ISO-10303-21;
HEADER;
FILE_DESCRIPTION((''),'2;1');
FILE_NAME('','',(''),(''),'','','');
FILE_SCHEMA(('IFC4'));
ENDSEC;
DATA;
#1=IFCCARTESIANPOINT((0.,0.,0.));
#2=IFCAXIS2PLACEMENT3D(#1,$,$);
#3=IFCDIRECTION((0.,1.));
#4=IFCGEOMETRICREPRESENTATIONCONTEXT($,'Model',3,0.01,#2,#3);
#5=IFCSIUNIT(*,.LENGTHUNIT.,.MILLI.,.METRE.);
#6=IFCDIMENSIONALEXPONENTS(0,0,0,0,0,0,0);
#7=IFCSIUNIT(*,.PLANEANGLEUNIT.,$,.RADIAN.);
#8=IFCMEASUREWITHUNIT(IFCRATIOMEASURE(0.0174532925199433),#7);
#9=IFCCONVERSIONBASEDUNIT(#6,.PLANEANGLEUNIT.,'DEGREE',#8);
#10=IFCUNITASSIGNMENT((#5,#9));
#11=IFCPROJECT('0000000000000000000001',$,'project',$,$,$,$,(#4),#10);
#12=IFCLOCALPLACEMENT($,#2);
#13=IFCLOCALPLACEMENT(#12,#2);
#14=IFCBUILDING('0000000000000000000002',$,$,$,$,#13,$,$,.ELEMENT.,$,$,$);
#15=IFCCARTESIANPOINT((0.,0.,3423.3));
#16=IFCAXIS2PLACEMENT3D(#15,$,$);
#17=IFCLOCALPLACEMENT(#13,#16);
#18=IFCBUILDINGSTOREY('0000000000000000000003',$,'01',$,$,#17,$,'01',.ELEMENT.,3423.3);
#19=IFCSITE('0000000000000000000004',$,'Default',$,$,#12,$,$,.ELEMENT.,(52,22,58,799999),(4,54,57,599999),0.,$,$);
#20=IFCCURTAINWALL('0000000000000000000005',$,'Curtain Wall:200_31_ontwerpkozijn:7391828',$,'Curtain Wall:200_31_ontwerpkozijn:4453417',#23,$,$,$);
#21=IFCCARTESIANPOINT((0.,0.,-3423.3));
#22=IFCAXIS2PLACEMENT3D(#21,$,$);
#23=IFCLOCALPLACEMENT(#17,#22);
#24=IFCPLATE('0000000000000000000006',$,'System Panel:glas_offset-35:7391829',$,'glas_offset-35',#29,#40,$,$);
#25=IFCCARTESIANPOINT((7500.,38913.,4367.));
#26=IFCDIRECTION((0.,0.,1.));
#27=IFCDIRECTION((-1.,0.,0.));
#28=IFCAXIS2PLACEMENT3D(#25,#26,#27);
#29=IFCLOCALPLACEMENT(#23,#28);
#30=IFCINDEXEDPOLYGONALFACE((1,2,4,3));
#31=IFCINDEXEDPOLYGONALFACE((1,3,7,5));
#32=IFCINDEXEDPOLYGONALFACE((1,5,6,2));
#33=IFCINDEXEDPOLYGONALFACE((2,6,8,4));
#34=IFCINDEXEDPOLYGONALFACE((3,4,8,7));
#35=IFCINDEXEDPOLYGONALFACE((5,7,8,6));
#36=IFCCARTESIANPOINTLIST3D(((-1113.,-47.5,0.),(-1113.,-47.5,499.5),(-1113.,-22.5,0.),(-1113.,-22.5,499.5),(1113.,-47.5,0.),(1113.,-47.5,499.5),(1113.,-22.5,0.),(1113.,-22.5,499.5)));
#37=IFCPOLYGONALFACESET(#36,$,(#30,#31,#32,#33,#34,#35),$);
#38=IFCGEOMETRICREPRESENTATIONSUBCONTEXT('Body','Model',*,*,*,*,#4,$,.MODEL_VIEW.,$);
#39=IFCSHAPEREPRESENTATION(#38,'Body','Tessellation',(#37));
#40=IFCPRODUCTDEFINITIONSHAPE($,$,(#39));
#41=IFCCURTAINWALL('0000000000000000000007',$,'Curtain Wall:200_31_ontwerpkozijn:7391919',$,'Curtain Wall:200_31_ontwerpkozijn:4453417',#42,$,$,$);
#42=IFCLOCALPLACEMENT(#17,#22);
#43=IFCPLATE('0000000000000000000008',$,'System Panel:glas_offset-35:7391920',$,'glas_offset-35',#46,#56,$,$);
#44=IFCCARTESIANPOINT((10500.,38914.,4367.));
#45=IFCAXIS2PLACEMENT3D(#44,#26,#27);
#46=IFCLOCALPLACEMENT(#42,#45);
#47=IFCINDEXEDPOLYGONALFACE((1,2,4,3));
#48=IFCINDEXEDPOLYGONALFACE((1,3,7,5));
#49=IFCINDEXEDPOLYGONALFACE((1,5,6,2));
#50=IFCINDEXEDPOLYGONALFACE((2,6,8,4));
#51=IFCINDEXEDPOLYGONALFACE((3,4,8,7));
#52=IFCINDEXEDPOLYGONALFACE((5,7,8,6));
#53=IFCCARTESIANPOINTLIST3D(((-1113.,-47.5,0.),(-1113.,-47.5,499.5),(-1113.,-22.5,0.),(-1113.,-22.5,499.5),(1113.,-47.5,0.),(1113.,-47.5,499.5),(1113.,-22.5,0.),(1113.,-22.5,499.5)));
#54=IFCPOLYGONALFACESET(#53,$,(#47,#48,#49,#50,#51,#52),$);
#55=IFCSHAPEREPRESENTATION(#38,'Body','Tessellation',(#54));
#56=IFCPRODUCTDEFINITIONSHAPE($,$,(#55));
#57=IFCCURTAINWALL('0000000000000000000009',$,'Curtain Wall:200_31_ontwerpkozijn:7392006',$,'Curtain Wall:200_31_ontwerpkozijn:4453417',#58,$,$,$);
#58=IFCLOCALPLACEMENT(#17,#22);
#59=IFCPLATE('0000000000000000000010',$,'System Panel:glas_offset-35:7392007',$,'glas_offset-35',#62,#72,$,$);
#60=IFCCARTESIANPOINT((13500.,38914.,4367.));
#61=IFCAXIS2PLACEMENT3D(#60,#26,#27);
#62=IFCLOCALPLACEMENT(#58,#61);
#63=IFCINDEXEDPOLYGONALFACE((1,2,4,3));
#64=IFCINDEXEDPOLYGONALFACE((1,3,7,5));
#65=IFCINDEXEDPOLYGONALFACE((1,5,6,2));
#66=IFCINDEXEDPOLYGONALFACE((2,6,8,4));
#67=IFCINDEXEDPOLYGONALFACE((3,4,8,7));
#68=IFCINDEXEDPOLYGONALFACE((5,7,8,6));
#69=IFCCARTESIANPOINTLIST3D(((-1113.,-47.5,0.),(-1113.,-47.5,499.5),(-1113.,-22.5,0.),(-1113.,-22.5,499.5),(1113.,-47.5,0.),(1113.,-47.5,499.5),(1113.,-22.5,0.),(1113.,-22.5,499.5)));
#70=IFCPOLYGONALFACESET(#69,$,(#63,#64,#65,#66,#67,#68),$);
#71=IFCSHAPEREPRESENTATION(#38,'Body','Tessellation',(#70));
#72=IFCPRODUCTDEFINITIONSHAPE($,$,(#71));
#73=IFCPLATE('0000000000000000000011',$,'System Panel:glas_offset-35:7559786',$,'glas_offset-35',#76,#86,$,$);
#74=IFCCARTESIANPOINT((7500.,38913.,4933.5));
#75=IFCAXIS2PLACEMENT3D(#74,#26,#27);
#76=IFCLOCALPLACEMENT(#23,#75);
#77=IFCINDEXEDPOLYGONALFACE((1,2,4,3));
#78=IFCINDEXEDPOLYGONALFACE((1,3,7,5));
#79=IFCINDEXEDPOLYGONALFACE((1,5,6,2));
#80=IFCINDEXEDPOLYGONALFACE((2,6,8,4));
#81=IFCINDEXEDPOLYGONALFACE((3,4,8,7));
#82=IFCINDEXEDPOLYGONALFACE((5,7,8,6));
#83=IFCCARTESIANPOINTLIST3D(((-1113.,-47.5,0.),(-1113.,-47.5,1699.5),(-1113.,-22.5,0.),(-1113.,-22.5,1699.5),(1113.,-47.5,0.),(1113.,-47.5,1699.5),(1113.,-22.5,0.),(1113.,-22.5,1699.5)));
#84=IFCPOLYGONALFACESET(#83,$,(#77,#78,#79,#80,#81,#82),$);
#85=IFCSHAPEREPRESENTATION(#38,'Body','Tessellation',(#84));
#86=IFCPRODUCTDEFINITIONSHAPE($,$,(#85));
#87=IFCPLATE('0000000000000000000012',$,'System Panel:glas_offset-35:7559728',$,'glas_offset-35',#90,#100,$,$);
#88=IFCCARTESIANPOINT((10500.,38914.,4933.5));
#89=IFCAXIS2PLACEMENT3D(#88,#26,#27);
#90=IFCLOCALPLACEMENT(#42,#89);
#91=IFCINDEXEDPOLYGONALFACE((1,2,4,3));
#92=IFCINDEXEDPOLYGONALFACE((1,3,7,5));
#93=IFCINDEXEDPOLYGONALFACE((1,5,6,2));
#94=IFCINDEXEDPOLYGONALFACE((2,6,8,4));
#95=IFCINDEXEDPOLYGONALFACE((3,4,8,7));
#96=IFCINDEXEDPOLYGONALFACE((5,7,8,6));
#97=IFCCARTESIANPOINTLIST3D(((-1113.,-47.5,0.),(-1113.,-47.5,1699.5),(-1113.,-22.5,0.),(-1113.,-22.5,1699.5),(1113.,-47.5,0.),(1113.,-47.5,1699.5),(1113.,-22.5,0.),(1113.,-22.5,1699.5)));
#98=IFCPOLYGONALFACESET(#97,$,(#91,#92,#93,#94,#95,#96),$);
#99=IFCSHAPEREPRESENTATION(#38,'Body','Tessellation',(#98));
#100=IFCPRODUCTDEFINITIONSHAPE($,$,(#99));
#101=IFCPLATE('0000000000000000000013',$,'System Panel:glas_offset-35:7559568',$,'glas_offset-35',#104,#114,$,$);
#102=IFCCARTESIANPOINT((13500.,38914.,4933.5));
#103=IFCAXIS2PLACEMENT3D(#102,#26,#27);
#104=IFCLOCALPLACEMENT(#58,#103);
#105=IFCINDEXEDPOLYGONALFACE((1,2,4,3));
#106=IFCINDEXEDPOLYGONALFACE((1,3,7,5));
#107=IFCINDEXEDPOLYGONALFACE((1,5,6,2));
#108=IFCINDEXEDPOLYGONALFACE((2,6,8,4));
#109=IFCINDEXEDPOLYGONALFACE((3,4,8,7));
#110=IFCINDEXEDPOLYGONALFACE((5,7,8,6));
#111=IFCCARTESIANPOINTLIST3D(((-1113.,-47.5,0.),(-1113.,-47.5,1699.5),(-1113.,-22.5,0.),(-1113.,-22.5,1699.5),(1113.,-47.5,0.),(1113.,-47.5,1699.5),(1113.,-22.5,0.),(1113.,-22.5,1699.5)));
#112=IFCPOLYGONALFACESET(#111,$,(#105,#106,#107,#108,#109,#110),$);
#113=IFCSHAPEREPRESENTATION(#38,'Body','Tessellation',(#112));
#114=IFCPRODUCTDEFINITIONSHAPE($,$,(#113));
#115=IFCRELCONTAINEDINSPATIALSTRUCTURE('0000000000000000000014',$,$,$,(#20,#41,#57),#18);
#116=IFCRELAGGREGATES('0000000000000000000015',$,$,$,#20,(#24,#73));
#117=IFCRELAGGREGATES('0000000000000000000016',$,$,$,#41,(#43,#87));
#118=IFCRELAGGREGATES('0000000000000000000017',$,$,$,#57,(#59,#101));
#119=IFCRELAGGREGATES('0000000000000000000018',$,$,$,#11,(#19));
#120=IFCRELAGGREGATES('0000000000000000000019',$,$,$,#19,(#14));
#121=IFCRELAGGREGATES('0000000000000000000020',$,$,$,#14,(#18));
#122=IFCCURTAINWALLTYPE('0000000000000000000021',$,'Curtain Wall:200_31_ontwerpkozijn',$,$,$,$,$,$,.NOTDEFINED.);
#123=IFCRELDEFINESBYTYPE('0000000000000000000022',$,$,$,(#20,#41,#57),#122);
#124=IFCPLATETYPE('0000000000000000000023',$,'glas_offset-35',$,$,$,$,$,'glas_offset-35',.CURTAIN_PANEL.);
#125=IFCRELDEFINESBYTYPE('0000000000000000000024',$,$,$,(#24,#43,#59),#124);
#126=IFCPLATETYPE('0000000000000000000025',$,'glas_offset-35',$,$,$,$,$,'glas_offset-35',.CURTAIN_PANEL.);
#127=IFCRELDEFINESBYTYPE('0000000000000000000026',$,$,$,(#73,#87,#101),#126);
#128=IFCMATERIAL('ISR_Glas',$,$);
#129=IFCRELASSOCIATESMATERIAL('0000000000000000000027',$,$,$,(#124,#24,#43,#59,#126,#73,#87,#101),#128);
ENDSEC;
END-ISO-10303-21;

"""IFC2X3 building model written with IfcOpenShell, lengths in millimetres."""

from ifc_helpers import new_model, entity, si_unit, converted_unit, direction, frame, frame_2d, origin, place, context, subcontext, project, spatial, rectangle, extrude, source, transform, mapped, material, type_object, type_shapes, element, aggregate, save


model = new_model("IFC2X3")

# Units and contexts
model_context = context("Model", 3, precision=0.01, world=origin(), true_north=direction((0.0, 1.0)))
body_context = subcontext(model_context, "Body", "Model", "MODEL_VIEW")
ifc_project = project(units=[si_unit("LENGTHUNIT", "METRE", prefix="MILLI"), converted_unit("PLANEANGLEUNIT", "DEGREE", entity("IfcRatioMeasure", 0.0174532925199433), si_unit("PLANEANGLEUNIT", "RADIAN"), dimensions=[0, 0, 0, 0, 0, 0, 0])], contexts=[model_context])

# Site, building, storey
site_placement = place(None, origin())
site = spatial("IfcSite", under=ifc_project, at=site_placement, Name="Default", CompositionType="ELEMENT", RefLatitude=(52, 22, 58, 799999), RefLongitude=(4, 54, 57, 599999), RefElevation=0.0)
building_placement = place(site_placement, origin())
building = spatial("IfcBuilding", under=site, at=building_placement, CompositionType="ELEMENT")
storey_placement = place(building_placement, frame((0.0, 0.0, 3423.3)))
storey = spatial("IfcBuildingStorey", under=building, at=storey_placement, Name="01", LongName="01", CompositionType="ELEMENT", Elevation=3423.3)

# Curtain walls, plates
curtain_wall_type = type_object("IfcCurtainWallType", Name="Curtain Wall:200_31_ontwerpkozijn", PredefinedType="NOTDEFINED")
curtain_wall_1_placement = place(storey_placement, frame((0.0, 0.0, -3423.3)))
curtain_wall_1 = element("IfcCurtainWall", 1, at=curtain_wall_1_placement, inside=storey, type_object=curtain_wall_type, Name="Curtain Wall:200_31_ontwerpkozijn:7391828", ObjectType="Curtain Wall:200_31_ontwerpkozijn:4453417")
ifc_material_1 = material(Name="ISR_Glas")
plate_type_1 = type_object("IfcPlateType", Name="glas_offset-35", ElementType="glas_offset-35", PredefinedType="CURTAIN_PANEL", material=ifc_material_1)
shared_shape_1 = source(origin(), body_context, "Body", "SweptSolid", [
    extrude(rectangle(XDim=25.0, YDim=2226.0, at=frame_2d((0.0, 0.0), x_axis=(1.0, 0.0))), frame((0.0, -35.0, 0.0), z_axis=(0.0, 0.0, 1.0), x_axis=(0.0, 1.0, 0.0)), (0.0, 0.0, 1.0), 499.5),
])
type_shapes(plate_type_1, [shared_shape_1])
plate_1_placement = place(curtain_wall_1_placement, frame((7500.0, 38913.0, 4367.0), z_axis=(0.0, 0.0, 1.0), x_axis=(-1.0, 0.0, 0.0)))
plate_1 = element("IfcPlate", 2, at=plate_1_placement, type_object=plate_type_1, material=ifc_material_1, Name="System Panel:glas_offset-35:7391829", ObjectType="glas_offset-35", context=body_context, shape_type="MappedRepresentation", body=[
    mapped(shared_shape_1, transform((0.0, 0.0, 0.0), scale=1.0)),
])
curtain_wall_2_placement = place(storey_placement, frame((0.0, 0.0, -3423.3)))
curtain_wall_2 = element("IfcCurtainWall", 3, at=curtain_wall_2_placement, inside=storey, type_object=curtain_wall_type, Name="Curtain Wall:200_31_ontwerpkozijn:7391919", ObjectType="Curtain Wall:200_31_ontwerpkozijn:4453417")
plate_2_placement = place(curtain_wall_2_placement, frame((10500.0, 38914.0, 4367.0), z_axis=(0.0, 0.0, 1.0), x_axis=(-1.0, 0.0, 0.0)))
plate_2 = element("IfcPlate", 4, at=plate_2_placement, type_object=plate_type_1, material=ifc_material_1, Name="System Panel:glas_offset-35:7391920", ObjectType="glas_offset-35", context=body_context, shape_type="MappedRepresentation", body=[
    mapped(shared_shape_1, transform((0.0, 0.0, 0.0), scale=1.0)),
])
curtain_wall_3_placement = place(storey_placement, frame((0.0, 0.0, -3423.3)))
curtain_wall_3 = element("IfcCurtainWall", 5, at=curtain_wall_3_placement, inside=storey, type_object=curtain_wall_type, Name="Curtain Wall:200_31_ontwerpkozijn:7392006", ObjectType="Curtain Wall:200_31_ontwerpkozijn:4453417")
plate_3_placement = place(curtain_wall_3_placement, frame((13500.0, 38914.0, 4367.0), z_axis=(0.0, 0.0, 1.0), x_axis=(-1.0, 0.0, 0.0)))
plate_3 = element("IfcPlate", 6, at=plate_3_placement, type_object=plate_type_1, material=ifc_material_1, Name="System Panel:glas_offset-35:7392007", ObjectType="glas_offset-35", context=body_context, shape_type="MappedRepresentation", body=[
    mapped(shared_shape_1, transform((0.0, 0.0, 0.0), scale=1.0)),
])

# Plates
plate_type_2 = type_object("IfcPlateType", Name="glas_offset-35", ElementType="glas_offset-35", PredefinedType="CURTAIN_PANEL", material=ifc_material_1)
shared_shape_2 = source(origin(), body_context, "Body", "SweptSolid", [
    extrude(rectangle(XDim=25.0, YDim=2226.0, at=frame_2d((0.0, 0.0), x_axis=(1.0, 0.0))), frame((0.0, -35.0, 0.0), z_axis=(0.0, 0.0, 1.0), x_axis=(0.0, 1.0, 0.0)), (0.0, 0.0, 1.0), 1699.5),
])
type_shapes(plate_type_2, [shared_shape_2])
plate_4_placement = place(curtain_wall_1_placement, frame((7500.0, 38913.0, 4933.5), z_axis=(0.0, 0.0, 1.0), x_axis=(-1.0, 0.0, 0.0)))
plate_4 = element("IfcPlate", 7, at=plate_4_placement, type_object=plate_type_2, material=ifc_material_1, Name="System Panel:glas_offset-35:7559786", ObjectType="glas_offset-35", context=body_context, shape_type="MappedRepresentation", body=[
    mapped(shared_shape_2, transform((0.0, 0.0, 0.0), scale=1.0)),
])
aggregate(curtain_wall_1, [plate_1, plate_4])
plate_5_placement = place(curtain_wall_2_placement, frame((10500.0, 38914.0, 4933.5), z_axis=(0.0, 0.0, 1.0), x_axis=(-1.0, 0.0, 0.0)))
plate_5 = element("IfcPlate", 8, at=plate_5_placement, type_object=plate_type_2, material=ifc_material_1, Name="System Panel:glas_offset-35:7559728", ObjectType="glas_offset-35", context=body_context, shape_type="MappedRepresentation", body=[
    mapped(shared_shape_2, transform((0.0, 0.0, 0.0), scale=1.0)),
])
aggregate(curtain_wall_2, [plate_2, plate_5])
plate_6_placement = place(curtain_wall_3_placement, frame((13500.0, 38914.0, 4933.5), z_axis=(0.0, 0.0, 1.0), x_axis=(-1.0, 0.0, 0.0)))
plate_6 = element("IfcPlate", 9, at=plate_6_placement, type_object=plate_type_2, material=ifc_material_1, Name="System Panel:glas_offset-35:7559568", ObjectType="glas_offset-35", context=body_context, shape_type="MappedRepresentation", body=[
    mapped(shared_shape_2, transform((0.0, 0.0, 0.0), scale=1.0)),
])
aggregate(curtain_wall_3, [plate_3, plate_6])

save(model, "model.ifc")
